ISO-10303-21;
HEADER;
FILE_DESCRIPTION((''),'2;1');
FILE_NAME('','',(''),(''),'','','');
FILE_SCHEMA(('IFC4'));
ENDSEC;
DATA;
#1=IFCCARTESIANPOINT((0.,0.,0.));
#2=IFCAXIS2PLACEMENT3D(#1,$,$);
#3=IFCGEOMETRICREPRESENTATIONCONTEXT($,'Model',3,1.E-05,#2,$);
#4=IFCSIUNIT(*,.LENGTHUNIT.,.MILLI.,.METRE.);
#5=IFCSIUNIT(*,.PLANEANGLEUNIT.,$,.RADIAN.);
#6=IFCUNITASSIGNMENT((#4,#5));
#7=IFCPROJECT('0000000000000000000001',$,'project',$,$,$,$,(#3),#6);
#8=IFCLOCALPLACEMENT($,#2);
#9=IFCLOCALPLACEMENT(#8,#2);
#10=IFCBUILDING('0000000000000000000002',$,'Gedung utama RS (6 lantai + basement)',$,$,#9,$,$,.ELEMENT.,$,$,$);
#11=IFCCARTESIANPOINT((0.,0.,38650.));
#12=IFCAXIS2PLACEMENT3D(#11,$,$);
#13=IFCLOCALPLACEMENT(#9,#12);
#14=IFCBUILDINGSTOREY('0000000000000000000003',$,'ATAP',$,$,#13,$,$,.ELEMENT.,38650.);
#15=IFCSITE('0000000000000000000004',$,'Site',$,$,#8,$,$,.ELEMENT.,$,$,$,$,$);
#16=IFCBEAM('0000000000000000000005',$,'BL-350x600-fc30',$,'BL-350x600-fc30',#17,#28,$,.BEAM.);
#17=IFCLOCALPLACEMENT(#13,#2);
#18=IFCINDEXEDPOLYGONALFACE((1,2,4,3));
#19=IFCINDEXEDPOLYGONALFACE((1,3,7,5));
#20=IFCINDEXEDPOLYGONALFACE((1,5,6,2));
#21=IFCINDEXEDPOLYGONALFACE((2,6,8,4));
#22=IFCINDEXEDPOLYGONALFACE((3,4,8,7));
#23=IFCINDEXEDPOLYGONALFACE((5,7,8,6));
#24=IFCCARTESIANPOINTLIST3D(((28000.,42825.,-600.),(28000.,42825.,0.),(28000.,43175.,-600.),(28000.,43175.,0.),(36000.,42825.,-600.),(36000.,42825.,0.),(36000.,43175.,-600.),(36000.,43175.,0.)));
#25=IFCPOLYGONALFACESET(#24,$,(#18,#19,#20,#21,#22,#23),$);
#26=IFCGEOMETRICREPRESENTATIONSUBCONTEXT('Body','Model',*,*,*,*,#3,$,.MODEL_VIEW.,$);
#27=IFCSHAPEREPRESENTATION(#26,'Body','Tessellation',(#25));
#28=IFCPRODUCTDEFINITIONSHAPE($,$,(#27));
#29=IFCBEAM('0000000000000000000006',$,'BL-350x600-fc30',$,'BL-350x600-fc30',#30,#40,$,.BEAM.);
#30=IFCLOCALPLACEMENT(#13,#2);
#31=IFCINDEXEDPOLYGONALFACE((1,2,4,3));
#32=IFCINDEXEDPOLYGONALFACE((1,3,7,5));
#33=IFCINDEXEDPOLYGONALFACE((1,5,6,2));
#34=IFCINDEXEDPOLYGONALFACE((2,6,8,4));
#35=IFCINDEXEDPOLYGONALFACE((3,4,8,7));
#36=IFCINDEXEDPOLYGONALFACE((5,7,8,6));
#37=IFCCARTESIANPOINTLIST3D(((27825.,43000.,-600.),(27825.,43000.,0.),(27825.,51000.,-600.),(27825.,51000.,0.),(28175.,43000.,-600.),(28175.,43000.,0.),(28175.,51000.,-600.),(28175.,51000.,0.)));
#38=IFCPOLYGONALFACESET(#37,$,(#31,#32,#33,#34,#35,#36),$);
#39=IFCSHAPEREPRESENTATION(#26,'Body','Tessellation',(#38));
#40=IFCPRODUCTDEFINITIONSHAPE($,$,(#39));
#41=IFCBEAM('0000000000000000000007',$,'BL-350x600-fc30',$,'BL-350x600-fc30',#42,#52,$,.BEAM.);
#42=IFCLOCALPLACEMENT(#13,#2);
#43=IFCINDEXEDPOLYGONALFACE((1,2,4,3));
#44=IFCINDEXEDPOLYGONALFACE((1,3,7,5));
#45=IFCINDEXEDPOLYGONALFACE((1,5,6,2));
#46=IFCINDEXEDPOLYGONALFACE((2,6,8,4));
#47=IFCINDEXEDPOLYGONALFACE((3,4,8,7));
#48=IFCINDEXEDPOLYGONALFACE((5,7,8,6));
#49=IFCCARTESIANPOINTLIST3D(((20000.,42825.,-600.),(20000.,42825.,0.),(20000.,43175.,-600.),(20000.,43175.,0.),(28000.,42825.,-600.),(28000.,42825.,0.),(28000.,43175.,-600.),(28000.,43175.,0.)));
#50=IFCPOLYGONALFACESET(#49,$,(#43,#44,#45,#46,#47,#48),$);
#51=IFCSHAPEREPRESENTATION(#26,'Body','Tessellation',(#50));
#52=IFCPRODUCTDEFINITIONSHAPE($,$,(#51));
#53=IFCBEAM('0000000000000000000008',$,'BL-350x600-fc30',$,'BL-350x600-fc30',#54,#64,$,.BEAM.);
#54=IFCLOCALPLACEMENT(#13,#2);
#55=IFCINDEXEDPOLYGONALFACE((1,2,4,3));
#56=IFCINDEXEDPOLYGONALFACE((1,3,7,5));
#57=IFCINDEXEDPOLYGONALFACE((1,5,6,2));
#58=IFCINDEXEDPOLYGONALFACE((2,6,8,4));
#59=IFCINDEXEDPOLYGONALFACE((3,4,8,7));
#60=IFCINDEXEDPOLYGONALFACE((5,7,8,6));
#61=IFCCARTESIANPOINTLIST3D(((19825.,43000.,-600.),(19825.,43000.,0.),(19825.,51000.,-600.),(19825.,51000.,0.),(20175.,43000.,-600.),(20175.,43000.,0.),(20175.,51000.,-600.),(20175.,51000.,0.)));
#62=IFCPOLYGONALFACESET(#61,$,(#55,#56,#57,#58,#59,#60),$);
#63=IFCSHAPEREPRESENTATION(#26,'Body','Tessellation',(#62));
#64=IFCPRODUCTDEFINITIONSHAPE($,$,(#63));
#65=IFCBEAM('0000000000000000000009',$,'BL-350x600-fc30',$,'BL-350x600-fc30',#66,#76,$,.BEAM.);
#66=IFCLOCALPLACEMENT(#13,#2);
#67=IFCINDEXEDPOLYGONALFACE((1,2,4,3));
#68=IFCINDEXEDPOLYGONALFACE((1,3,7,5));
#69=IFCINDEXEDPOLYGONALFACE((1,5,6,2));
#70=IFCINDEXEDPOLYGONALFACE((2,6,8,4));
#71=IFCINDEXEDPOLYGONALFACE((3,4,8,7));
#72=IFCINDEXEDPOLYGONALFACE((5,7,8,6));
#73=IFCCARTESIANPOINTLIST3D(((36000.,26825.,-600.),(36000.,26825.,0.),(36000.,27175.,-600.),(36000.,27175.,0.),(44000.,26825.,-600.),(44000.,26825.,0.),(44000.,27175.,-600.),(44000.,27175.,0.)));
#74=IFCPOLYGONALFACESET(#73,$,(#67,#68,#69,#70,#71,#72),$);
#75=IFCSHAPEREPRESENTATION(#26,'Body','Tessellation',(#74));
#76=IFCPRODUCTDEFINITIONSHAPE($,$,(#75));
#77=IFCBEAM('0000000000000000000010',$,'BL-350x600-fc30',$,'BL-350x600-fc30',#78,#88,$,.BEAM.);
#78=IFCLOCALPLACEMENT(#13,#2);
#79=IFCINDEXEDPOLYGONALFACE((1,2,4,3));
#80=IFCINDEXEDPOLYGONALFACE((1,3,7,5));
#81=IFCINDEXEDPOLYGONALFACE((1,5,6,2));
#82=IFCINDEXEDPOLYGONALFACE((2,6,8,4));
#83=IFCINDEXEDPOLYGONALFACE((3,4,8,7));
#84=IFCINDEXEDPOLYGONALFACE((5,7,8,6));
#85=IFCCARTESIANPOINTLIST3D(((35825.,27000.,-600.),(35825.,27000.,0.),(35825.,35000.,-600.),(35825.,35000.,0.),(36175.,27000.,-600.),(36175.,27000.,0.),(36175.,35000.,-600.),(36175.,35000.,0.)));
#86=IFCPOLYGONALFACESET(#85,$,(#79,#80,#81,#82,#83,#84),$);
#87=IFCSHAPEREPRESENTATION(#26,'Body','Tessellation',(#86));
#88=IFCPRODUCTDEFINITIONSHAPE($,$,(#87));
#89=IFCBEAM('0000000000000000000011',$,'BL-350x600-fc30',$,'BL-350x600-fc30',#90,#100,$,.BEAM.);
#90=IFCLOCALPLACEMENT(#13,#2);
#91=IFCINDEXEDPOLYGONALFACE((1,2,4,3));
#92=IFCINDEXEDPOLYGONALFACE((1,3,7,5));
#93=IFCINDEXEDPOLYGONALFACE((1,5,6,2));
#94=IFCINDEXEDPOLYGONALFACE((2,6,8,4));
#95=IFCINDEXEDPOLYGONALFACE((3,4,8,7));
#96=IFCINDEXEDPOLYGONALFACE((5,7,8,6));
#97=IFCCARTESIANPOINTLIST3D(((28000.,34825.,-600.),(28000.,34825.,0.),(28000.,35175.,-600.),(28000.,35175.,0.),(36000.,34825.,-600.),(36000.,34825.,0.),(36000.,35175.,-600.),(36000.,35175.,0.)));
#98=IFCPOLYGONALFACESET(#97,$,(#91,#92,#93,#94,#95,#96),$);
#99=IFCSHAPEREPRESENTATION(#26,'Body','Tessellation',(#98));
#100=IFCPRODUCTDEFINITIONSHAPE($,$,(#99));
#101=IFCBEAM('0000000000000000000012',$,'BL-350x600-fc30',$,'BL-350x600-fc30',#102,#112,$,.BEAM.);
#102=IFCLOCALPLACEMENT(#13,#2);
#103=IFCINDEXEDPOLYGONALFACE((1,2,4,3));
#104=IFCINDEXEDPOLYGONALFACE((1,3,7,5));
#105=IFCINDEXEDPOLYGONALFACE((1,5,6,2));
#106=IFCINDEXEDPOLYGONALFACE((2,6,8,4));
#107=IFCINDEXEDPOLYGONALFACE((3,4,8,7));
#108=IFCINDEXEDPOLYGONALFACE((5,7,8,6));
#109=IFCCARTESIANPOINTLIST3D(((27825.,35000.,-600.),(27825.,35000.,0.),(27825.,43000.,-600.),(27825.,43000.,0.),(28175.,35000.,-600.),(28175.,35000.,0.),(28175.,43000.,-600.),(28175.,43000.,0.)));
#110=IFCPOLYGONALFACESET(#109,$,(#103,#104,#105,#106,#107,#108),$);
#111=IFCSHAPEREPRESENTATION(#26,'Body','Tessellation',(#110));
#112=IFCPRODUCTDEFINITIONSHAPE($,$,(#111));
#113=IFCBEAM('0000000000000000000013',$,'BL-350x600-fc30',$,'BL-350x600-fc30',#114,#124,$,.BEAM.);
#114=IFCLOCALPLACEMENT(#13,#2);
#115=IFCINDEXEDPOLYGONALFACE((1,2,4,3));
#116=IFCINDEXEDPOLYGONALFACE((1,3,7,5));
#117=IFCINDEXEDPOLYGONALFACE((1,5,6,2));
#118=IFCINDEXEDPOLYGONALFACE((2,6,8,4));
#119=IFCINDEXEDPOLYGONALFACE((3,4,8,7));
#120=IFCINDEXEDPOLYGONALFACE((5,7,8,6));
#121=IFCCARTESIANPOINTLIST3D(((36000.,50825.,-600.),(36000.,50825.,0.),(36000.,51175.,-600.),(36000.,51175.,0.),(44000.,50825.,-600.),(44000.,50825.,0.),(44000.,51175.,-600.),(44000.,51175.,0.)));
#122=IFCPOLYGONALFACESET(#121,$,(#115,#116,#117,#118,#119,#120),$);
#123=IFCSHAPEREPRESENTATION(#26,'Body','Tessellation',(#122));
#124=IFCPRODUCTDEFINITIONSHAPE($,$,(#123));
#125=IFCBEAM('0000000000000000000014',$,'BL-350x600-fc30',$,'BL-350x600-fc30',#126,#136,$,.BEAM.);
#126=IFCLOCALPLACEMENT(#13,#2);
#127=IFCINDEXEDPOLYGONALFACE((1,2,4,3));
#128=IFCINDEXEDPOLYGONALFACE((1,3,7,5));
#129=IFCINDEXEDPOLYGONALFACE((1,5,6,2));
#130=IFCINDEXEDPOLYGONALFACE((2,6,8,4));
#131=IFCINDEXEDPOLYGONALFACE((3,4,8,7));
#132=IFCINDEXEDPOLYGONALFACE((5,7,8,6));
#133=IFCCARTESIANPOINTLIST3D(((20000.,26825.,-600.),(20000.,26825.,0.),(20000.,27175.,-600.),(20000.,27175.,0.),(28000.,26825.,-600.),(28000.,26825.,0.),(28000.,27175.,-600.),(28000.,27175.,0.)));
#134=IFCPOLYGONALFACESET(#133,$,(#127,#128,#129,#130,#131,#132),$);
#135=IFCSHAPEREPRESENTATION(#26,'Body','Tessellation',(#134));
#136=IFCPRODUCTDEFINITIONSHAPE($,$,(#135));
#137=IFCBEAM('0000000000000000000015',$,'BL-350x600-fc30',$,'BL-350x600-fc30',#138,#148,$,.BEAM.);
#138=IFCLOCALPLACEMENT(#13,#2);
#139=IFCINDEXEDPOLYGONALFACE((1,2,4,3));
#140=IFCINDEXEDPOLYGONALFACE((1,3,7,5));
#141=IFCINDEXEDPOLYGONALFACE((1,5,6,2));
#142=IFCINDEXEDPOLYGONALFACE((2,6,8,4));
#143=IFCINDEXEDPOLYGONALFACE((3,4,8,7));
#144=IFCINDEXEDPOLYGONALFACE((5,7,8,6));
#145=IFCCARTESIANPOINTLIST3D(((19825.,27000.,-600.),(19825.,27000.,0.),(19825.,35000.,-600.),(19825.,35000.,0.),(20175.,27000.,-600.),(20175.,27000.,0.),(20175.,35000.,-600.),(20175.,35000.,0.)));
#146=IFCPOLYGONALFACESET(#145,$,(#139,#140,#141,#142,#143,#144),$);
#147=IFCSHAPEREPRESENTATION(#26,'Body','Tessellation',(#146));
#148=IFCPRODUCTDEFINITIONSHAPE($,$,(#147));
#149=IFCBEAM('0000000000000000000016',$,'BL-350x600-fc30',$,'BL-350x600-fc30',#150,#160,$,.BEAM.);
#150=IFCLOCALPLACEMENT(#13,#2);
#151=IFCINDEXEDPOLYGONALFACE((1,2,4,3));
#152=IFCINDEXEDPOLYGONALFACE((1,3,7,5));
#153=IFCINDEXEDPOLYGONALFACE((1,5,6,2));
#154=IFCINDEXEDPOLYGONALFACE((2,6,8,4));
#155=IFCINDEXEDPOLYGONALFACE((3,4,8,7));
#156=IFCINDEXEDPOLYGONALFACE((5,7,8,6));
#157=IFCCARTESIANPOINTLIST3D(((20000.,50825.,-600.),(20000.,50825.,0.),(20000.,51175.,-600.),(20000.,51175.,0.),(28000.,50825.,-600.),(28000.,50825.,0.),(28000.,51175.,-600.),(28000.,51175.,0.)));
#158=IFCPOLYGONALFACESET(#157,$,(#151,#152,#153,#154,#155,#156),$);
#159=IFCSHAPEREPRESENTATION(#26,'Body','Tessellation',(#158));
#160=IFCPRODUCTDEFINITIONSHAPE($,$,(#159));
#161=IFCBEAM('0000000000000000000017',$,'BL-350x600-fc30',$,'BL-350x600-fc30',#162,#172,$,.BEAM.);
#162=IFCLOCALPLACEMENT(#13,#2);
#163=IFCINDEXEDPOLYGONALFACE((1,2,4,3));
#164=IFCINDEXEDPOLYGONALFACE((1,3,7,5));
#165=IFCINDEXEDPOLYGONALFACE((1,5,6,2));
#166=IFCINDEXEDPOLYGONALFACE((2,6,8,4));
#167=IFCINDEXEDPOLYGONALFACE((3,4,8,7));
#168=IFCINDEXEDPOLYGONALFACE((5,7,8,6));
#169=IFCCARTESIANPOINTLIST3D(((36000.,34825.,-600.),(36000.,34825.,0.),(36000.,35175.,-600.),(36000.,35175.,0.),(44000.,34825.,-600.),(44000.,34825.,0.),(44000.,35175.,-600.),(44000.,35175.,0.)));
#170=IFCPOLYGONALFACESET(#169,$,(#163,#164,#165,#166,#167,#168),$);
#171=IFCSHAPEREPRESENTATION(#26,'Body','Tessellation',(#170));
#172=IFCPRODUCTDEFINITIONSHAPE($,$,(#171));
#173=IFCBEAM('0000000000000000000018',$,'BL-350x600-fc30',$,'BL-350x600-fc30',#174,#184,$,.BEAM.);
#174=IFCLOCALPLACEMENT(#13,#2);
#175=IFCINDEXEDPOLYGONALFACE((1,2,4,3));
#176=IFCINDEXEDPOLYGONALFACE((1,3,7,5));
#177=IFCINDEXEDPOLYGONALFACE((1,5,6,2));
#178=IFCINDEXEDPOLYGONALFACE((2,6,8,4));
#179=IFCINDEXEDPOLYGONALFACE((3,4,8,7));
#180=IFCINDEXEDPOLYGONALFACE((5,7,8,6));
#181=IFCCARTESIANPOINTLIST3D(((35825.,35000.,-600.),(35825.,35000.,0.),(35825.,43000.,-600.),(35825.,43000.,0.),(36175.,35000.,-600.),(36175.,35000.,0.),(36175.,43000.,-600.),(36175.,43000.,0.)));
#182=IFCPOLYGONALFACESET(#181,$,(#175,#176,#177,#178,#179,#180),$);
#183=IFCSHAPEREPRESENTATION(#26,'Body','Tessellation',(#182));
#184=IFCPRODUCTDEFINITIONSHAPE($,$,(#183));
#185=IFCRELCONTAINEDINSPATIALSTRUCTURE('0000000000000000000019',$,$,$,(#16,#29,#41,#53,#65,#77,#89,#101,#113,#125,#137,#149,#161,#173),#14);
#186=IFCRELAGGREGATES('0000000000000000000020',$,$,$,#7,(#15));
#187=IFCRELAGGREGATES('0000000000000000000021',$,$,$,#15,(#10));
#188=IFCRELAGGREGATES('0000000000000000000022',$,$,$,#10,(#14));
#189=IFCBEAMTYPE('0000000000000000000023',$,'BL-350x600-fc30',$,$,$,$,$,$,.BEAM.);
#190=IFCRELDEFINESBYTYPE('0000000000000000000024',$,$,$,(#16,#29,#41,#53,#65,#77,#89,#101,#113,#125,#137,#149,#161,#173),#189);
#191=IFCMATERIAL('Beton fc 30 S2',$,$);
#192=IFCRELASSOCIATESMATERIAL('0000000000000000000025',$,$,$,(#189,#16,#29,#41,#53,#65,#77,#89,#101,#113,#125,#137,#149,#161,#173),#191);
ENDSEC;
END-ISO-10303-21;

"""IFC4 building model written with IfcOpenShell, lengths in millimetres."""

from ifc_helpers import new_model, si_unit, frame, origin, origin_2d, place, context, subcontext, project, spatial, rectangle, extrude, material, material_profile, profile_set, profile_usage, type_object, element, save


model = new_model("IFC4")

# Units and contexts
model_context = context("Model", 3, precision=1e-05, world=origin())
body_context = subcontext(model_context, "Body", "Model", "MODEL_VIEW")
ifc_project = project(units=[si_unit("LENGTHUNIT", "METRE", prefix="MILLI"), si_unit("PLANEANGLEUNIT", "RADIAN")], contexts=[model_context])

# Site, building, storey
site_placement = place(None, origin())
site = spatial("IfcSite", under=ifc_project, at=site_placement, Name="Site", CompositionType="ELEMENT")
building_placement = place(site_placement, origin())
building = spatial("IfcBuilding", under=site, at=building_placement, Name="Gedung utama RS (6 lantai + basement)", CompositionType="ELEMENT")
storey_placement = place(building_placement, frame((0.0, 0.0, 38650.0)))
storey = spatial("IfcBuildingStorey", under=building, at=storey_placement, Name="ATAP", CompositionType="ELEMENT", Elevation=38650.0)

# Beams
ifc_material = material(Name="Beton fc 30 S2")
ifc_material_profile_1 = material_profile(ifc_material, rectangle(XDim=350.0, YDim=600.0, at=origin_2d()), Name="BL-350x600-fc30")
ifc_profile_set_1 = profile_set([ifc_material_profile_1], Name="BL-350x600-fc30")
ifc_profile_usage_1 = profile_usage(ifc_profile_set_1, cardinal=8)
beam_type = type_object("IfcBeamType", Name="BL-350x600-fc30", PredefinedType="BEAM", material=ifc_profile_set_1)
for number, where, name in (
    (1, (28000.0, 43000.0, -300.0), "BL-350x600-fc30"),
):
    element("IfcBeam", number, at=place(storey_placement, frame(where)), inside=storey, type_object=beam_type, material=ifc_profile_usage_1, Name=name, ObjectType="BL-350x600-fc30", PredefinedType="BEAM", context=body_context, shape_type="SweptSolid", body=[
        extrude(rectangle(XDim=350.0, YDim=600.0, at=origin_2d()), frame((0.0, 0.0, 0.0), z_axis=(1.0, 0.0, 0.0), x_axis=(0.0, 1.0, 0.0)), (0.0, 0.0, 1.0), 8000.0),
    ])
beam_1_placement = place(storey_placement, frame((28000.0, 43000.0, -300.0)))
element("IfcBeam", 2, at=beam_1_placement, inside=storey, type_object=beam_type, material=ifc_profile_usage_1, Name="BL-350x600-fc30", ObjectType="BL-350x600-fc30", PredefinedType="BEAM", context=body_context, shape_type="SweptSolid", body=[
    extrude(rectangle(XDim=350.0, YDim=600.0, at=origin_2d()), frame((0.0, 0.0, 0.0), z_axis=(0.0, 1.0, 0.0), x_axis=(-1.0, 0.0, 0.0)), (0.0, 0.0, 1.0), 8000.0),
])
beam_2_placement = place(storey_placement, frame((20000.0, 43000.0, -300.0)))
element("IfcBeam", 3, at=beam_2_placement, inside=storey, type_object=beam_type, material=ifc_profile_usage_1, Name="BL-350x600-fc30", ObjectType="BL-350x600-fc30", PredefinedType="BEAM", context=body_context, shape_type="SweptSolid", body=[
    extrude(rectangle(XDim=350.0, YDim=600.0, at=origin_2d()), frame((0.0, 0.0, 0.0), z_axis=(1.0, 0.0, 0.0), x_axis=(0.0, 1.0, 0.0)), (0.0, 0.0, 1.0), 8000.0),
])
beam_3_placement = place(storey_placement, frame((20000.0, 43000.0, -300.0)))
element("IfcBeam", 4, at=beam_3_placement, inside=storey, type_object=beam_type, material=ifc_profile_usage_1, Name="BL-350x600-fc30", ObjectType="BL-350x600-fc30", PredefinedType="BEAM", context=body_context, shape_type="SweptSolid", body=[
    extrude(rectangle(XDim=350.0, YDim=600.0, at=origin_2d()), frame((0.0, 0.0, 0.0), z_axis=(0.0, 1.0, 0.0), x_axis=(-1.0, 0.0, 0.0)), (0.0, 0.0, 1.0), 8000.0),
])
beam_4_placement = place(storey_placement, frame((36000.0, 27000.0, -300.0)))
element("IfcBeam", 5, at=beam_4_placement, inside=storey, type_object=beam_type, material=ifc_profile_usage_1, Name="BL-350x600-fc30", ObjectType="BL-350x600-fc30", PredefinedType="BEAM", context=body_context, shape_type="SweptSolid", body=[
    extrude(rectangle(XDim=350.0, YDim=600.0, at=origin_2d()), frame((0.0, 0.0, 0.0), z_axis=(1.0, 0.0, 0.0), x_axis=(0.0, 1.0, 0.0)), (0.0, 0.0, 1.0), 8000.0),
])
beam_5_placement = place(storey_placement, frame((36000.0, 27000.0, -300.0)))
element("IfcBeam", 6, at=beam_5_placement, inside=storey, type_object=beam_type, material=ifc_profile_usage_1, Name="BL-350x600-fc30", ObjectType="BL-350x600-fc30", PredefinedType="BEAM", context=body_context, shape_type="SweptSolid", body=[
    extrude(rectangle(XDim=350.0, YDim=600.0, at=origin_2d()), frame((0.0, 0.0, 0.0), z_axis=(0.0, 1.0, 0.0), x_axis=(-1.0, 0.0, 0.0)), (0.0, 0.0, 1.0), 8000.0),
])
beam_6_placement = place(storey_placement, frame((28000.0, 35000.0, -300.0)))
element("IfcBeam", 7, at=beam_6_placement, inside=storey, type_object=beam_type, material=ifc_profile_usage_1, Name="BL-350x600-fc30", ObjectType="BL-350x600-fc30", PredefinedType="BEAM", context=body_context, shape_type="SweptSolid", body=[
    extrude(rectangle(XDim=350.0, YDim=600.0, at=origin_2d()), frame((0.0, 0.0, 0.0), z_axis=(1.0, 0.0, 0.0), x_axis=(0.0, 1.0, 0.0)), (0.0, 0.0, 1.0), 8000.0),
])
beam_7_placement = place(storey_placement, frame((28000.0, 35000.0, -300.0)))
element("IfcBeam", 8, at=beam_7_placement, inside=storey, type_object=beam_type, material=ifc_profile_usage_1, Name="BL-350x600-fc30", ObjectType="BL-350x600-fc30", PredefinedType="BEAM", context=body_context, shape_type="SweptSolid", body=[
    extrude(rectangle(XDim=350.0, YDim=600.0, at=origin_2d()), frame((0.0, 0.0, 0.0), z_axis=(0.0, 1.0, 0.0), x_axis=(-1.0, 0.0, 0.0)), (0.0, 0.0, 1.0), 8000.0),
])
for number, where, name in (
    (9, (36000.0, 51000.0, -300.0), "BL-350x600-fc30"),
    (10, (20000.0, 27000.0, -300.0), "BL-350x600-fc30"),
):
    element("IfcBeam", number, at=place(storey_placement, frame(where)), inside=storey, type_object=beam_type, material=ifc_profile_usage_1, Name=name, ObjectType="BL-350x600-fc30", PredefinedType="BEAM", context=body_context, shape_type="SweptSolid", body=[
        extrude(rectangle(XDim=350.0, YDim=600.0, at=origin_2d()), frame((0.0, 0.0, 0.0), z_axis=(1.0, 0.0, 0.0), x_axis=(0.0, 1.0, 0.0)), (0.0, 0.0, 1.0), 8000.0),
    ])
beam_8_placement = place(storey_placement, frame((20000.0, 27000.0, -300.0)))
element("IfcBeam", 11, at=beam_8_placement, inside=storey, type_object=beam_type, material=ifc_profile_usage_1, Name="BL-350x600-fc30", ObjectType="BL-350x600-fc30", PredefinedType="BEAM", context=body_context, shape_type="SweptSolid", body=[
    extrude(rectangle(XDim=350.0, YDim=600.0, at=origin_2d()), frame((0.0, 0.0, 0.0), z_axis=(0.0, 1.0, 0.0), x_axis=(-1.0, 0.0, 0.0)), (0.0, 0.0, 1.0), 8000.0),
])
for number, where, name in (
    (12, (20000.0, 51000.0, -300.0), "BL-350x600-fc30"),
    (13, (36000.0, 35000.0, -300.0), "BL-350x600-fc30"),
):
    element("IfcBeam", number, at=place(storey_placement, frame(where)), inside=storey, type_object=beam_type, material=ifc_profile_usage_1, Name=name, ObjectType="BL-350x600-fc30", PredefinedType="BEAM", context=body_context, shape_type="SweptSolid", body=[
        extrude(rectangle(XDim=350.0, YDim=600.0, at=origin_2d()), frame((0.0, 0.0, 0.0), z_axis=(1.0, 0.0, 0.0), x_axis=(0.0, 1.0, 0.0)), (0.0, 0.0, 1.0), 8000.0),
    ])
beam_9_placement = place(storey_placement, frame((36000.0, 35000.0, -300.0)))
element("IfcBeam", 14, at=beam_9_placement, inside=storey, type_object=beam_type, material=ifc_profile_usage_1, Name="BL-350x600-fc30", ObjectType="BL-350x600-fc30", PredefinedType="BEAM", context=body_context, shape_type="SweptSolid", body=[
    extrude(rectangle(XDim=350.0, YDim=600.0, at=origin_2d()), frame((0.0, 0.0, 0.0), z_axis=(0.0, 1.0, 0.0), x_axis=(-1.0, 0.0, 0.0)), (0.0, 0.0, 1.0), 8000.0),
])

save(model, "model.ifc")
